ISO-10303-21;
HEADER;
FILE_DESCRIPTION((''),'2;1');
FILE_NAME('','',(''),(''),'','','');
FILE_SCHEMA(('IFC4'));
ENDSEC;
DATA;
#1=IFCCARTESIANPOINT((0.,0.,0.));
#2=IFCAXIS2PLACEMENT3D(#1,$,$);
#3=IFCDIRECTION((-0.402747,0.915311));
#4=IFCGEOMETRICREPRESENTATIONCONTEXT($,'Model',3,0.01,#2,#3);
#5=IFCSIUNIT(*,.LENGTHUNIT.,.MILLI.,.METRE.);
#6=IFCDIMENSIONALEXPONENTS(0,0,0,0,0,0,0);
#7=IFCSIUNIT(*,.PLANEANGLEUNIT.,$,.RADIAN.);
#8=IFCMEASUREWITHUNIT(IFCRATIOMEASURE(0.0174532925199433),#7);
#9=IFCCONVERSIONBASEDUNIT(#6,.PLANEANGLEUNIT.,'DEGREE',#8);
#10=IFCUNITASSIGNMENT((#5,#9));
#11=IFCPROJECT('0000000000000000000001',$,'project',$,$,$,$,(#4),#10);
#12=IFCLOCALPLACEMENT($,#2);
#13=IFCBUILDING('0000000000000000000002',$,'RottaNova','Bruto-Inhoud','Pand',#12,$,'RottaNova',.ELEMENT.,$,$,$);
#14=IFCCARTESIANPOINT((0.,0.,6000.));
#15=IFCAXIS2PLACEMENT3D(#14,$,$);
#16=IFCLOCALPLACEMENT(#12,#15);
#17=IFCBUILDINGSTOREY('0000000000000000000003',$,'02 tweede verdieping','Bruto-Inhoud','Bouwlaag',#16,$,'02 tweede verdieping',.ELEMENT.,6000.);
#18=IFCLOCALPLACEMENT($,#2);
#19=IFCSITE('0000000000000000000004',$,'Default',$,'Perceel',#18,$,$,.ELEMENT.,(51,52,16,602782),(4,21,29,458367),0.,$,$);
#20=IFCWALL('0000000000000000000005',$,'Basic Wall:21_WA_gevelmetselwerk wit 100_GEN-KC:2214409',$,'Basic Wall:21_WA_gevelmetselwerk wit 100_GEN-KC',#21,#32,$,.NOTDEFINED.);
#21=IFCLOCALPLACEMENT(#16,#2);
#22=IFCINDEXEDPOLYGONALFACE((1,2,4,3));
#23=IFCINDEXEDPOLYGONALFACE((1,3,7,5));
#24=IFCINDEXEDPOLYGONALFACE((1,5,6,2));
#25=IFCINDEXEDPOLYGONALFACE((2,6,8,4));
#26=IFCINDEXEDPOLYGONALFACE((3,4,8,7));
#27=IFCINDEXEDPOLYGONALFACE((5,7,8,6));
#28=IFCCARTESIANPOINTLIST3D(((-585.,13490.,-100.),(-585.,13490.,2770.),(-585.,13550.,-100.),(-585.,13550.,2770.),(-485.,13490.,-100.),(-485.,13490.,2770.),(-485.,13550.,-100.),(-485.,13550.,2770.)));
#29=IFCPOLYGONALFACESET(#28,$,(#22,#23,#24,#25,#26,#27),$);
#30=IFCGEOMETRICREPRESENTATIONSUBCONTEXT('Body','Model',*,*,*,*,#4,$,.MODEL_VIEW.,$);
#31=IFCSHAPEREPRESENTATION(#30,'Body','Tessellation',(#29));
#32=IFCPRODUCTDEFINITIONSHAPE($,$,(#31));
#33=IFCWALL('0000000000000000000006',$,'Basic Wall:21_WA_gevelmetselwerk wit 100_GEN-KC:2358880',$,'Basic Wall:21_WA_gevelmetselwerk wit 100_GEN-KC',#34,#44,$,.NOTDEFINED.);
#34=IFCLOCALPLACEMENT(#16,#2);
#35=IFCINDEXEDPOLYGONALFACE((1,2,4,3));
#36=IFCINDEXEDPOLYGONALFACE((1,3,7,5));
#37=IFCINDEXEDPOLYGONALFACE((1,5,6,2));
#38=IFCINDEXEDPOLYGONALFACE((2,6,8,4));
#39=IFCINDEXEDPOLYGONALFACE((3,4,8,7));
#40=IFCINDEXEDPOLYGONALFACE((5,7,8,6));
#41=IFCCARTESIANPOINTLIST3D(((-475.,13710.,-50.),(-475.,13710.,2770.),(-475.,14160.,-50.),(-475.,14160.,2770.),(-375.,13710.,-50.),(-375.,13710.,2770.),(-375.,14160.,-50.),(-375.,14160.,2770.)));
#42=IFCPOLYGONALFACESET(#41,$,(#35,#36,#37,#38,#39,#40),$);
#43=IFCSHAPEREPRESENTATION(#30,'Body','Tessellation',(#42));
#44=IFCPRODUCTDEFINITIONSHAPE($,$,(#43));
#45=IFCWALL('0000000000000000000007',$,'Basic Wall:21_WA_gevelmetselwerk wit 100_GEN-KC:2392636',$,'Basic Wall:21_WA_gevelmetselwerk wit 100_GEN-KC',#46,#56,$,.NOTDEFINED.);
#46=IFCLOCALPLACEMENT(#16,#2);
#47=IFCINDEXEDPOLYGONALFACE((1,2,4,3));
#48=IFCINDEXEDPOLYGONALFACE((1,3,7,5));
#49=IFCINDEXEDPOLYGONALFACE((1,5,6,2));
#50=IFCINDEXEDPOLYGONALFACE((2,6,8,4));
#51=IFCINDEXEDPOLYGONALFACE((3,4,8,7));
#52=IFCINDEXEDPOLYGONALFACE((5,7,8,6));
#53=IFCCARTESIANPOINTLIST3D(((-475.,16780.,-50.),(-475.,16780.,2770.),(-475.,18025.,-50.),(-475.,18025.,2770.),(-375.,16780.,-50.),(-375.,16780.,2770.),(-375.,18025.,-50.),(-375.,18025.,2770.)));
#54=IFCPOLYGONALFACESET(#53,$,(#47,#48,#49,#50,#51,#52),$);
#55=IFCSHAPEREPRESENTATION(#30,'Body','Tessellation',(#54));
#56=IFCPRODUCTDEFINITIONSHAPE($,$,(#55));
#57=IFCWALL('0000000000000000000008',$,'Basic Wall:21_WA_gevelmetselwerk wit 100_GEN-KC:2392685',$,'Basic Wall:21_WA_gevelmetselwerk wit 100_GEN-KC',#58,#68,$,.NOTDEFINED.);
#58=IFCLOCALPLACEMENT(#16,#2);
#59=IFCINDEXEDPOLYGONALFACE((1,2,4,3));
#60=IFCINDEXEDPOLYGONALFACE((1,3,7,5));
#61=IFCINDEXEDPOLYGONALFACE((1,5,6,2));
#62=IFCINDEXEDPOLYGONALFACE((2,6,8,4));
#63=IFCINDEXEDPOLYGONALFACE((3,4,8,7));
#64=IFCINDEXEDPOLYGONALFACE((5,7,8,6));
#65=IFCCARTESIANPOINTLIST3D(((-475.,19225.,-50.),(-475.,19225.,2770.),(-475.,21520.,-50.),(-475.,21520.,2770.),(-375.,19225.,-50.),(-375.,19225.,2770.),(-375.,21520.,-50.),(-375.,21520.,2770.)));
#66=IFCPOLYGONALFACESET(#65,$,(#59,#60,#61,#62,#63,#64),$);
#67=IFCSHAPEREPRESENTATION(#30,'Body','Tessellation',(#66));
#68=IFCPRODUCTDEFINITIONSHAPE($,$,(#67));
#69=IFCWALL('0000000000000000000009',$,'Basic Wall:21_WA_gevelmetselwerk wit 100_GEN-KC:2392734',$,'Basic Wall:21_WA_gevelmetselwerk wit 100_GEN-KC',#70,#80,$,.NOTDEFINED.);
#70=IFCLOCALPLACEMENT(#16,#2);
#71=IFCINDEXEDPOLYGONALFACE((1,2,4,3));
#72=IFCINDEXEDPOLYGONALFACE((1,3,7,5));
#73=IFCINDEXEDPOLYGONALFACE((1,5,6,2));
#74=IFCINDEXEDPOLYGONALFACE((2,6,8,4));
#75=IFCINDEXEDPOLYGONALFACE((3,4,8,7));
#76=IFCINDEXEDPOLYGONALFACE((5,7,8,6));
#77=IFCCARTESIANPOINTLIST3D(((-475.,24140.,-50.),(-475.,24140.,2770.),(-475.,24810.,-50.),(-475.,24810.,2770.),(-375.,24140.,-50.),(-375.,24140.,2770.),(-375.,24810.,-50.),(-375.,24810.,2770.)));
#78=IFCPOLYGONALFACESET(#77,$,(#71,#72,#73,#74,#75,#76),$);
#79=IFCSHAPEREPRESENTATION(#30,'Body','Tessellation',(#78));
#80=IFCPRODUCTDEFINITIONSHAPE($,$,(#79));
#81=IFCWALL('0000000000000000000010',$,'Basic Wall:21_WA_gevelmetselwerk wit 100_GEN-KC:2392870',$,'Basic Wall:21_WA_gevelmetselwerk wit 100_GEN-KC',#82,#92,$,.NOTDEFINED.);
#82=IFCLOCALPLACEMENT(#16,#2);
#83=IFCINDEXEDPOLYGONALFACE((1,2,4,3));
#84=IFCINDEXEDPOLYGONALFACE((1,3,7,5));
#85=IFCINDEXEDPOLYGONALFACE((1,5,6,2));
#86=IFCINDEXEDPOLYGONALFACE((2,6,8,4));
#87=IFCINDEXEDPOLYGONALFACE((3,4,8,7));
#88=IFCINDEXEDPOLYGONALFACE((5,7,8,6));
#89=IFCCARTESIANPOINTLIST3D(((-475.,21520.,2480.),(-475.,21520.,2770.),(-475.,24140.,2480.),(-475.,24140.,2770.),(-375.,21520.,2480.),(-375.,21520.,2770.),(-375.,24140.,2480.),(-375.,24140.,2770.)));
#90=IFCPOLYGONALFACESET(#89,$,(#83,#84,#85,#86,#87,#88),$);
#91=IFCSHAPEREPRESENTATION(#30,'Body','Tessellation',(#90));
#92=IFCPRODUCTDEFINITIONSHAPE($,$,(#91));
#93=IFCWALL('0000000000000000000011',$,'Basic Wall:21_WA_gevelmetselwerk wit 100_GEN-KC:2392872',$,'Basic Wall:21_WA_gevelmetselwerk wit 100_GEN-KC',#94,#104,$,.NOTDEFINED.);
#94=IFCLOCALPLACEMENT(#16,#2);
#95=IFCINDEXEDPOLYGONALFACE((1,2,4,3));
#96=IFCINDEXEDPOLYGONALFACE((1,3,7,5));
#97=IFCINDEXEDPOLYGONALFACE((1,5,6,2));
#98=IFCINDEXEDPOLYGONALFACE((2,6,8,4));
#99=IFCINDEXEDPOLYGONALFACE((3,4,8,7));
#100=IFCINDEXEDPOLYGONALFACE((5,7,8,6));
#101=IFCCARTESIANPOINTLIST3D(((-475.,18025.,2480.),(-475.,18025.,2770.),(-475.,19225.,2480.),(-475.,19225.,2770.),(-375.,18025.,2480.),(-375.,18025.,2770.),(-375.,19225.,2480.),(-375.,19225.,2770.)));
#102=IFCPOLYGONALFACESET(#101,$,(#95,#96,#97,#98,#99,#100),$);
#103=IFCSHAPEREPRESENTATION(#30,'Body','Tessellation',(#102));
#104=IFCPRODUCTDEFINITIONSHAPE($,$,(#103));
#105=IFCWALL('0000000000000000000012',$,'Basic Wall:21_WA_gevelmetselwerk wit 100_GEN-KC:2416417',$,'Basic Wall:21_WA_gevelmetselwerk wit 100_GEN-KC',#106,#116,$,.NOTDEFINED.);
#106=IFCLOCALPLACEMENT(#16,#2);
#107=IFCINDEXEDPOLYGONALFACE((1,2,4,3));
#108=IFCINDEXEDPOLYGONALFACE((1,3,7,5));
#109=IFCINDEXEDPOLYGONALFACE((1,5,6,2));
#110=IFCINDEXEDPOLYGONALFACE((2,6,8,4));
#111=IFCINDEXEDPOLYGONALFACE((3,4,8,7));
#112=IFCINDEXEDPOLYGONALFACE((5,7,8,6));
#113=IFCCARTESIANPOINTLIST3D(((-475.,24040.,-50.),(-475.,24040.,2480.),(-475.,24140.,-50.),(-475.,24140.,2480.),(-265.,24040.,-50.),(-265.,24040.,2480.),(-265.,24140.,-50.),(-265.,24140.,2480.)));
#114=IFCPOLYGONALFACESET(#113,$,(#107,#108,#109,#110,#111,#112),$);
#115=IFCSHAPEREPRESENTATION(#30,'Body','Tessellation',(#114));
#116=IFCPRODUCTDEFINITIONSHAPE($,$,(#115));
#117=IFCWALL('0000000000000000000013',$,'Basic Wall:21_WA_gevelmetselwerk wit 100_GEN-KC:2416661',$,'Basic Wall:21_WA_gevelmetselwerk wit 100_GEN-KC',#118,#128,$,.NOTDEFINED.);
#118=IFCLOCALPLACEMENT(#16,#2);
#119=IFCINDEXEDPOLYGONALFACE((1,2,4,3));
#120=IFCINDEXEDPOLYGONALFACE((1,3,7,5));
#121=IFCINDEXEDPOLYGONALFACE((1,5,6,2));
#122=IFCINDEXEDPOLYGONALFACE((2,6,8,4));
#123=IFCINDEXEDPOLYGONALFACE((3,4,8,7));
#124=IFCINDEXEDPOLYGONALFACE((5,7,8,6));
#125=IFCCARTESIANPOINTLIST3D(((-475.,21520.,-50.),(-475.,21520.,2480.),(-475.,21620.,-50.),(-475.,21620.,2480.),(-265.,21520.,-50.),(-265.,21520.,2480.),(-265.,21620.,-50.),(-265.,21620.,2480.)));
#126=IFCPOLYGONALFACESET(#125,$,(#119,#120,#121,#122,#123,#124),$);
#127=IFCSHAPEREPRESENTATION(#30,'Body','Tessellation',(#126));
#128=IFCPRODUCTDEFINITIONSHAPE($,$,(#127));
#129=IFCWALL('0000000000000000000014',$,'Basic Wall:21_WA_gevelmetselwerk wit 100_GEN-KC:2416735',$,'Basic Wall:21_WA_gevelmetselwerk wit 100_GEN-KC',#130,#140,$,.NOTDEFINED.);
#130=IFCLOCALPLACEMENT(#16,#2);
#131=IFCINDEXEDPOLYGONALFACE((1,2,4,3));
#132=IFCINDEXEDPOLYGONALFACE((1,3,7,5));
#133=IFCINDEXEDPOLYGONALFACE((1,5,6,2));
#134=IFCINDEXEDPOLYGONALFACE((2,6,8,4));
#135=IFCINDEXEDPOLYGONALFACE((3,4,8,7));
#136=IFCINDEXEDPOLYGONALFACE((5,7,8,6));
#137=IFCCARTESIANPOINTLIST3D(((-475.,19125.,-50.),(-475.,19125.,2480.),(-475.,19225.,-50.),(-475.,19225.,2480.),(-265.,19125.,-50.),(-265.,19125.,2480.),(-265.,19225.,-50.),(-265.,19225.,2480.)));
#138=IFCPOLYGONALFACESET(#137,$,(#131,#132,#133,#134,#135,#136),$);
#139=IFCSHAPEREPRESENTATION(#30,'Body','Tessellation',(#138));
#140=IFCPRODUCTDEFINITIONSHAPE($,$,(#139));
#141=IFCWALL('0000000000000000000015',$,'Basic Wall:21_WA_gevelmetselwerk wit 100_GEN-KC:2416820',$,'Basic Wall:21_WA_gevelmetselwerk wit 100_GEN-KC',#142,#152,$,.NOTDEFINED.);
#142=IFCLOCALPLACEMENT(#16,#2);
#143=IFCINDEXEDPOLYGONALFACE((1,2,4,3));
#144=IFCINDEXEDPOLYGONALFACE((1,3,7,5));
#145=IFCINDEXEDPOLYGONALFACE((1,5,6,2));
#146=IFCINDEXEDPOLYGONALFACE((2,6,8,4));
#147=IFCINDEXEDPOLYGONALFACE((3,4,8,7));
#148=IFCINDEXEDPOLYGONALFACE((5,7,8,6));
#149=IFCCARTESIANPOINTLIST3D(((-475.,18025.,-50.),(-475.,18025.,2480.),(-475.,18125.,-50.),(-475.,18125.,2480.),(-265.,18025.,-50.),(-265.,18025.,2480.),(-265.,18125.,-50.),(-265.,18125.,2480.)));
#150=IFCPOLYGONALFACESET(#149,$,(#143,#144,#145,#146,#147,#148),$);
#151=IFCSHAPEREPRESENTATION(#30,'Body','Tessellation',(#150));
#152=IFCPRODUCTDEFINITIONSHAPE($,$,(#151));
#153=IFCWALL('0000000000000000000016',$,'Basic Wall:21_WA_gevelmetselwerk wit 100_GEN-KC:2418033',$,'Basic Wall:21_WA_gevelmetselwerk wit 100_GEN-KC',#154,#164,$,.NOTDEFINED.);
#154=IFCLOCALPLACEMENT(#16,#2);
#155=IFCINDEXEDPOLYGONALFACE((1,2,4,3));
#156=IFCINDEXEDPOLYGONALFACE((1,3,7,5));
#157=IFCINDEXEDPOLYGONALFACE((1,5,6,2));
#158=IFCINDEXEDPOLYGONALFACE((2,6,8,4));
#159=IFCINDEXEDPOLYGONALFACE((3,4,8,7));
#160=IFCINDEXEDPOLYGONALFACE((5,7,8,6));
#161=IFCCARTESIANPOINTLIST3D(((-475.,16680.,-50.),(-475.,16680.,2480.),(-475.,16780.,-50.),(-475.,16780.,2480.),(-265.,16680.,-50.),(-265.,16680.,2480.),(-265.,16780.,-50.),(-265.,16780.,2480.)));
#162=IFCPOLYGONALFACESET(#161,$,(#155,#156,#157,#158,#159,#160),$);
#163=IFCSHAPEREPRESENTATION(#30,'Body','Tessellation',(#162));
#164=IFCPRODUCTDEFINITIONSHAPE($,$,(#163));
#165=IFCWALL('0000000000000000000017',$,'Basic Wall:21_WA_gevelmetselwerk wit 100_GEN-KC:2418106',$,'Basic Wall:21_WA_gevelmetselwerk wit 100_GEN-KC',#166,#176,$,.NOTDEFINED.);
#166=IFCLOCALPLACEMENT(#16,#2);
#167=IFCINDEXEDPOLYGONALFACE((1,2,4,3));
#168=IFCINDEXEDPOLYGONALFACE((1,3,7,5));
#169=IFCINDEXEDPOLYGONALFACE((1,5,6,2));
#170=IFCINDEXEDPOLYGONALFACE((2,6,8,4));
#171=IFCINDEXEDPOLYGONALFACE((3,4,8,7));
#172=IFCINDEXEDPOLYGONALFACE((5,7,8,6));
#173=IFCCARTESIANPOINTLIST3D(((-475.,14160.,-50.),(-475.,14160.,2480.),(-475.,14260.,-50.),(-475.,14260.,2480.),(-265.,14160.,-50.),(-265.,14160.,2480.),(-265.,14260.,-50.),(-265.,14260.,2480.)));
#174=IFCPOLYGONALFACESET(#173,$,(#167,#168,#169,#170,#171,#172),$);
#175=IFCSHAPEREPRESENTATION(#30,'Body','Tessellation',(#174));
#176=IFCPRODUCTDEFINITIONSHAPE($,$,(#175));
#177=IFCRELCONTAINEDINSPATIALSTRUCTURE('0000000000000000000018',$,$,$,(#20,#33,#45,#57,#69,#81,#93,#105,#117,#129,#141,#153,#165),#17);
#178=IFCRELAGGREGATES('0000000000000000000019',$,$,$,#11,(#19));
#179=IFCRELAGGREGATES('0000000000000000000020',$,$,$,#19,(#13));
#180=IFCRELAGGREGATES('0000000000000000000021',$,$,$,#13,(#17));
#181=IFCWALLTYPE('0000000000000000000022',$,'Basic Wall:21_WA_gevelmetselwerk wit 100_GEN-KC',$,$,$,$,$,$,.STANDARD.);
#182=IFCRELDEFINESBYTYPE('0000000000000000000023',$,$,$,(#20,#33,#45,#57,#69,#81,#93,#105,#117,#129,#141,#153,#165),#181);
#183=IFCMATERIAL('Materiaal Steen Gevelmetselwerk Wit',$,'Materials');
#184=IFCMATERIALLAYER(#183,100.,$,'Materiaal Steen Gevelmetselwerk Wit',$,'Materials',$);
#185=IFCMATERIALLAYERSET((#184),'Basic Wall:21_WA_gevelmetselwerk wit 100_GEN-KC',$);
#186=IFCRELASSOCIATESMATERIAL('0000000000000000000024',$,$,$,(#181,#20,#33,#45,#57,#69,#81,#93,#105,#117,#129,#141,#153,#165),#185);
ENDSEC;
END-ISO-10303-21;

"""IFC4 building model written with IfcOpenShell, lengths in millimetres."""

from ifc_helpers import new_model, entity, si_unit, converted_unit, direction, frame, frame_2d, origin, place, context, subcontext, project, spatial, polyline, rectangle, extrude, clip, bounded_halfspace, material, layer, layer_set, type_object, element, save


model = new_model("IFC4")

# Units and contexts
model_context = context("Model", 3, precision=0.01, world=origin(), true_north=direction((-0.402747, 0.915311)))
body_context = subcontext(model_context, "Body", "Model", "MODEL_VIEW")
ifc_project = project(units=[si_unit("LENGTHUNIT", "METRE", prefix="MILLI"), converted_unit("PLANEANGLEUNIT", "DEGREE", entity("IfcRatioMeasure", 0.0174532925199433), si_unit("PLANEANGLEUNIT", "RADIAN"), dimensions=[0, 0, 0, 0, 0, 0, 0])], contexts=[model_context])

# Site, building, storey
site_placement = place(None, origin())
site = spatial("IfcSite", under=ifc_project, at=site_placement, Name="Default", ObjectType="Perceel", CompositionType="ELEMENT", RefLatitude=(51, 52, 16, 602782), RefLongitude=(4, 21, 29, 458367), RefElevation=0.0)
building_placement = place(None, origin())
building = spatial("IfcBuilding", under=site, at=building_placement, Name="RottaNova", Description="Bruto-Inhoud", ObjectType="Pand", LongName="RottaNova", CompositionType="ELEMENT")
storey_placement = place(building_placement, frame((0.0, 0.0, 6000.0)))
storey = spatial("IfcBuildingStorey", under=building, at=storey_placement, Name="02 tweede verdieping", Description="Bruto-Inhoud", ObjectType="Bouwlaag", LongName="02 tweede verdieping", CompositionType="ELEMENT", Elevation=6000.0)

# Walls
ifc_material_1 = material(Name="Materiaal Steen Gevelmetselwerk Wit", Category="Materials")
ifc_layer_1 = layer(ifc_material_1, 100.0, Name="Materiaal Steen Gevelmetselwerk Wit", Category="Materials")
ifc_layer_set_1 = layer_set([ifc_layer_1], Name="Basic Wall:21_WA_gevelmetselwerk wit 100_GEN-KC")
wall_type_1 = type_object("IfcWallType", Name="Basic Wall:21_WA_gevelmetselwerk wit 100_GEN-KC", PredefinedType="STANDARD", material=ifc_layer_set_1)
wall_1_placement = place(storey_placement, frame((-535.0, 13550.0, -100.0), z_axis=(0.0, 0.0, 1.0), x_axis=(0.0, -1.0, 0.0)))
element("IfcWall", 1, at=wall_1_placement, inside=storey, type_object=wall_type_1, material=ifc_layer_set_1, Name="Basic Wall:21_WA_gevelmetselwerk wit 100_GEN-KC:2214409", ObjectType="Basic Wall:21_WA_gevelmetselwerk wit 100_GEN-KC", PredefinedType="NOTDEFINED", context=body_context, shape_type="SweptSolid", body=[
    extrude(rectangle(XDim=60.0, YDim=100.0, at=frame_2d((30.0, 0.0), x_axis=(-1.0, 0.0))), origin(), (0.0, 0.0, 1.0), 2870.0),
])
wall_2_placement = place(storey_placement, frame((-425.0, 13710.0, -50.0), z_axis=(0.0, 0.0, 1.0), x_axis=(0.0, 1.0, 0.0)))
element("IfcWall", 2, at=wall_2_placement, inside=storey, type_object=wall_type_1, material=ifc_layer_set_1, Name="Basic Wall:21_WA_gevelmetselwerk wit 100_GEN-KC:2358880", ObjectType="Basic Wall:21_WA_gevelmetselwerk wit 100_GEN-KC", PredefinedType="NOTDEFINED", context=body_context, shape_type="SweptSolid", body=[
    extrude(rectangle(XDim=450.0, YDim=100.0, at=frame_2d((225.0, 0.0), x_axis=(-1.0, 0.0))), origin(), (0.0, 0.0, 1.0), 2820.0),
])
wall_3_placement = place(storey_placement, frame((-425.0, 16780.0, -50.0), z_axis=(0.0, 0.0, 1.0), x_axis=(0.0, 1.0, 0.0)))
element("IfcWall", 3, at=wall_3_placement, inside=storey, type_object=wall_type_1, material=ifc_layer_set_1, Name="Basic Wall:21_WA_gevelmetselwerk wit 100_GEN-KC:2392636", ObjectType="Basic Wall:21_WA_gevelmetselwerk wit 100_GEN-KC", PredefinedType="NOTDEFINED", context=body_context, shape_type="SweptSolid", body=[
    extrude(rectangle(XDim=1245.0, YDim=100.0, at=frame_2d((622.5, 0.0), x_axis=(-1.0, 0.0))), origin(), (0.0, 0.0, 1.0), 2820.0),
])
wall_4_placement = place(storey_placement, frame((-425.0, 19225.0, -50.0), z_axis=(0.0, 0.0, 1.0), x_axis=(0.0, 1.0, 0.0)))
element("IfcWall", 4, at=wall_4_placement, inside=storey, type_object=wall_type_1, material=ifc_layer_set_1, Name="Basic Wall:21_WA_gevelmetselwerk wit 100_GEN-KC:2392685", ObjectType="Basic Wall:21_WA_gevelmetselwerk wit 100_GEN-KC", PredefinedType="NOTDEFINED", context=body_context, shape_type="SweptSolid", body=[
    extrude(rectangle(XDim=2295.0, YDim=100.0, at=frame_2d((1147.5, 0.0), x_axis=(-1.0, 0.0))), origin(), (0.0, 0.0, 1.0), 2820.0),
])
wall_5_placement = place(storey_placement, frame((-425.0, 24140.0, -50.0), z_axis=(0.0, 0.0, 1.0), x_axis=(0.0, 1.0, 0.0)))
element("IfcWall", 5, at=wall_5_placement, inside=storey, type_object=wall_type_1, material=ifc_layer_set_1, Name="Basic Wall:21_WA_gevelmetselwerk wit 100_GEN-KC:2392734", ObjectType="Basic Wall:21_WA_gevelmetselwerk wit 100_GEN-KC", PredefinedType="NOTDEFINED", context=body_context, shape_type="SweptSolid", body=[
    extrude(rectangle(XDim=670.0, YDim=100.0, at=frame_2d((335.0, 0.0), x_axis=(-1.0, 0.0))), origin(), (0.0, 0.0, 1.0), 2820.0),
])
wall_6_placement = place(storey_placement, frame((-425.0, 24140.0, 2480.0), z_axis=(0.0, 0.0, 1.0), x_axis=(0.0, -1.0, 0.0)))
element("IfcWall", 6, at=wall_6_placement, inside=storey, type_object=wall_type_1, material=ifc_layer_set_1, Name="Basic Wall:21_WA_gevelmetselwerk wit 100_GEN-KC:2392870", ObjectType="Basic Wall:21_WA_gevelmetselwerk wit 100_GEN-KC", PredefinedType="NOTDEFINED", context=body_context, shape_type="Clipping", body=[
    clip(extrude(rectangle(XDim=2620.0, YDim=100.0, at=frame_2d((1310.0, 0.0), x_axis=(-1.0, 0.0))), origin(), (0.0, 0.0, 1.0), 290.0), bounded_halfspace(frame((2620.0, -50.0, 290.0), z_axis=(1.0, 0.0, 0.0), x_axis=(0.0, 1.0, 0.0)), False, frame((2620.0, -50.0, 290.0), z_axis=(1.0, 0.0, 0.0), x_axis=(0.0, 1.0, 0.0)), polyline([(0.0, 0.0), (0.0, -88392.0), (30480.0, -88392.0), (30480.0, 0.0), (0.0, 0.0)]))),
])
wall_7_placement = place(storey_placement, frame((-425.0, 19225.0, 2480.0), z_axis=(0.0, 0.0, 1.0), x_axis=(0.0, -1.0, 0.0)))
element("IfcWall", 7, at=wall_7_placement, inside=storey, type_object=wall_type_1, material=ifc_layer_set_1, Name="Basic Wall:21_WA_gevelmetselwerk wit 100_GEN-KC:2392872", ObjectType="Basic Wall:21_WA_gevelmetselwerk wit 100_GEN-KC", PredefinedType="NOTDEFINED", context=body_context, shape_type="SweptSolid", body=[
    extrude(rectangle(XDim=1200.0, YDim=100.0, at=frame_2d((600.0, 0.0), x_axis=(-1.0, 0.0))), origin(), (0.0, 0.0, 1.0), 290.0),
])
for number, where, z_axis, x_axis, name in (
    (8, (-265.0, 24090.0, -50.0), (0.0, 0.0, 1.0), (-1.0, 0.0, 0.0), "Basic Wall:21_WA_gevelmetselwerk wit 100_GEN-KC:2416417"),
    (9, (-265.0, 21570.0, -50.0), (0.0, 0.0, 1.0), (-1.0, 0.0, 0.0), "Basic Wall:21_WA_gevelmetselwerk wit 100_GEN-KC:2416661"),
):
    element("IfcWall", number, at=place(storey_placement, frame(where, z_axis=z_axis, x_axis=x_axis)), inside=storey, type_object=wall_type_1, material=ifc_layer_set_1, Name=name, ObjectType="Basic Wall:21_WA_gevelmetselwerk wit 100_GEN-KC", PredefinedType="NOTDEFINED", context=body_context, shape_type="SweptSolid", body=[
        extrude(rectangle(XDim=210.0, YDim=100.0, at=frame_2d((105.0, 0.0), x_axis=(-1.0, 0.0))), origin(), (0.0, 0.0, 1.0), 2530.0),
    ])
wall_8_placement = place(storey_placement, frame((-265.0, 19175.0, -50.0), z_axis=(0.0, 0.0, 1.0), x_axis=(-1.0, 0.0, 0.0)))
element("IfcWall", 10, at=wall_8_placement, inside=storey, type_object=wall_type_1, material=ifc_layer_set_1, Name="Basic Wall:21_WA_gevelmetselwerk wit 100_GEN-KC:2416735", ObjectType="Basic Wall:21_WA_gevelmetselwerk wit 100_GEN-KC", PredefinedType="NOTDEFINED", context=body_context, shape_type="SweptSolid", body=[
    extrude(rectangle(XDim=210.0, YDim=100.0, at=frame_2d((105.0, 0.0), x_axis=(-1.0, 0.0))), origin(), (0.0, 0.0, 1.0), 2530.0),
])
wall_9_placement = place(storey_placement, frame((-265.0, 18075.0, -50.0), z_axis=(0.0, 0.0, 1.0), x_axis=(-1.0, 0.0, 0.0)))
element("IfcWall", 11, at=wall_9_placement, inside=storey, type_object=wall_type_1, material=ifc_layer_set_1, Name="Basic Wall:21_WA_gevelmetselwerk wit 100_GEN-KC:2416820", ObjectType="Basic Wall:21_WA_gevelmetselwerk wit 100_GEN-KC", PredefinedType="NOTDEFINED", context=body_context, shape_type="SweptSolid", body=[
    extrude(rectangle(XDim=210.0, YDim=100.0, at=frame_2d((105.0, 0.0), x_axis=(-1.0, 0.0))), origin(), (0.0, 0.0, 1.0), 2530.0),
])
wall_10_placement = place(storey_placement, frame((-265.0, 16730.0, -50.0), z_axis=(0.0, 0.0, 1.0), x_axis=(-1.0, 0.0, 0.0)))
element("IfcWall", 12, at=wall_10_placement, inside=storey, type_object=wall_type_1, material=ifc_layer_set_1, Name="Basic Wall:21_WA_gevelmetselwerk wit 100_GEN-KC:2418033", ObjectType="Basic Wall:21_WA_gevelmetselwerk wit 100_GEN-KC", PredefinedType="NOTDEFINED", context=body_context, shape_type="SweptSolid", body=[
    extrude(rectangle(XDim=210.0, YDim=100.0, at=frame_2d((105.0, 0.0), x_axis=(-1.0, 0.0))), origin(), (0.0, 0.0, 1.0), 2530.0),
])
wall_11_placement = place(storey_placement, frame((-265.0, 14210.0, -50.0), z_axis=(0.0, 0.0, 1.0), x_axis=(-1.0, 0.0, 0.0)))
element("IfcWall", 13, at=wall_11_placement, inside=storey, type_object=wall_type_1, material=ifc_layer_set_1, Name="Basic Wall:21_WA_gevelmetselwerk wit 100_GEN-KC:2418106", ObjectType="Basic Wall:21_WA_gevelmetselwerk wit 100_GEN-KC", PredefinedType="NOTDEFINED", context=body_context, shape_type="SweptSolid", body=[
    extrude(rectangle(XDim=210.0, YDim=100.0, at=frame_2d((105.0, 0.0), x_axis=(-1.0, 0.0))), origin(), (0.0, 0.0, 1.0), 2530.0),
])

save(model, "model.ifc")
